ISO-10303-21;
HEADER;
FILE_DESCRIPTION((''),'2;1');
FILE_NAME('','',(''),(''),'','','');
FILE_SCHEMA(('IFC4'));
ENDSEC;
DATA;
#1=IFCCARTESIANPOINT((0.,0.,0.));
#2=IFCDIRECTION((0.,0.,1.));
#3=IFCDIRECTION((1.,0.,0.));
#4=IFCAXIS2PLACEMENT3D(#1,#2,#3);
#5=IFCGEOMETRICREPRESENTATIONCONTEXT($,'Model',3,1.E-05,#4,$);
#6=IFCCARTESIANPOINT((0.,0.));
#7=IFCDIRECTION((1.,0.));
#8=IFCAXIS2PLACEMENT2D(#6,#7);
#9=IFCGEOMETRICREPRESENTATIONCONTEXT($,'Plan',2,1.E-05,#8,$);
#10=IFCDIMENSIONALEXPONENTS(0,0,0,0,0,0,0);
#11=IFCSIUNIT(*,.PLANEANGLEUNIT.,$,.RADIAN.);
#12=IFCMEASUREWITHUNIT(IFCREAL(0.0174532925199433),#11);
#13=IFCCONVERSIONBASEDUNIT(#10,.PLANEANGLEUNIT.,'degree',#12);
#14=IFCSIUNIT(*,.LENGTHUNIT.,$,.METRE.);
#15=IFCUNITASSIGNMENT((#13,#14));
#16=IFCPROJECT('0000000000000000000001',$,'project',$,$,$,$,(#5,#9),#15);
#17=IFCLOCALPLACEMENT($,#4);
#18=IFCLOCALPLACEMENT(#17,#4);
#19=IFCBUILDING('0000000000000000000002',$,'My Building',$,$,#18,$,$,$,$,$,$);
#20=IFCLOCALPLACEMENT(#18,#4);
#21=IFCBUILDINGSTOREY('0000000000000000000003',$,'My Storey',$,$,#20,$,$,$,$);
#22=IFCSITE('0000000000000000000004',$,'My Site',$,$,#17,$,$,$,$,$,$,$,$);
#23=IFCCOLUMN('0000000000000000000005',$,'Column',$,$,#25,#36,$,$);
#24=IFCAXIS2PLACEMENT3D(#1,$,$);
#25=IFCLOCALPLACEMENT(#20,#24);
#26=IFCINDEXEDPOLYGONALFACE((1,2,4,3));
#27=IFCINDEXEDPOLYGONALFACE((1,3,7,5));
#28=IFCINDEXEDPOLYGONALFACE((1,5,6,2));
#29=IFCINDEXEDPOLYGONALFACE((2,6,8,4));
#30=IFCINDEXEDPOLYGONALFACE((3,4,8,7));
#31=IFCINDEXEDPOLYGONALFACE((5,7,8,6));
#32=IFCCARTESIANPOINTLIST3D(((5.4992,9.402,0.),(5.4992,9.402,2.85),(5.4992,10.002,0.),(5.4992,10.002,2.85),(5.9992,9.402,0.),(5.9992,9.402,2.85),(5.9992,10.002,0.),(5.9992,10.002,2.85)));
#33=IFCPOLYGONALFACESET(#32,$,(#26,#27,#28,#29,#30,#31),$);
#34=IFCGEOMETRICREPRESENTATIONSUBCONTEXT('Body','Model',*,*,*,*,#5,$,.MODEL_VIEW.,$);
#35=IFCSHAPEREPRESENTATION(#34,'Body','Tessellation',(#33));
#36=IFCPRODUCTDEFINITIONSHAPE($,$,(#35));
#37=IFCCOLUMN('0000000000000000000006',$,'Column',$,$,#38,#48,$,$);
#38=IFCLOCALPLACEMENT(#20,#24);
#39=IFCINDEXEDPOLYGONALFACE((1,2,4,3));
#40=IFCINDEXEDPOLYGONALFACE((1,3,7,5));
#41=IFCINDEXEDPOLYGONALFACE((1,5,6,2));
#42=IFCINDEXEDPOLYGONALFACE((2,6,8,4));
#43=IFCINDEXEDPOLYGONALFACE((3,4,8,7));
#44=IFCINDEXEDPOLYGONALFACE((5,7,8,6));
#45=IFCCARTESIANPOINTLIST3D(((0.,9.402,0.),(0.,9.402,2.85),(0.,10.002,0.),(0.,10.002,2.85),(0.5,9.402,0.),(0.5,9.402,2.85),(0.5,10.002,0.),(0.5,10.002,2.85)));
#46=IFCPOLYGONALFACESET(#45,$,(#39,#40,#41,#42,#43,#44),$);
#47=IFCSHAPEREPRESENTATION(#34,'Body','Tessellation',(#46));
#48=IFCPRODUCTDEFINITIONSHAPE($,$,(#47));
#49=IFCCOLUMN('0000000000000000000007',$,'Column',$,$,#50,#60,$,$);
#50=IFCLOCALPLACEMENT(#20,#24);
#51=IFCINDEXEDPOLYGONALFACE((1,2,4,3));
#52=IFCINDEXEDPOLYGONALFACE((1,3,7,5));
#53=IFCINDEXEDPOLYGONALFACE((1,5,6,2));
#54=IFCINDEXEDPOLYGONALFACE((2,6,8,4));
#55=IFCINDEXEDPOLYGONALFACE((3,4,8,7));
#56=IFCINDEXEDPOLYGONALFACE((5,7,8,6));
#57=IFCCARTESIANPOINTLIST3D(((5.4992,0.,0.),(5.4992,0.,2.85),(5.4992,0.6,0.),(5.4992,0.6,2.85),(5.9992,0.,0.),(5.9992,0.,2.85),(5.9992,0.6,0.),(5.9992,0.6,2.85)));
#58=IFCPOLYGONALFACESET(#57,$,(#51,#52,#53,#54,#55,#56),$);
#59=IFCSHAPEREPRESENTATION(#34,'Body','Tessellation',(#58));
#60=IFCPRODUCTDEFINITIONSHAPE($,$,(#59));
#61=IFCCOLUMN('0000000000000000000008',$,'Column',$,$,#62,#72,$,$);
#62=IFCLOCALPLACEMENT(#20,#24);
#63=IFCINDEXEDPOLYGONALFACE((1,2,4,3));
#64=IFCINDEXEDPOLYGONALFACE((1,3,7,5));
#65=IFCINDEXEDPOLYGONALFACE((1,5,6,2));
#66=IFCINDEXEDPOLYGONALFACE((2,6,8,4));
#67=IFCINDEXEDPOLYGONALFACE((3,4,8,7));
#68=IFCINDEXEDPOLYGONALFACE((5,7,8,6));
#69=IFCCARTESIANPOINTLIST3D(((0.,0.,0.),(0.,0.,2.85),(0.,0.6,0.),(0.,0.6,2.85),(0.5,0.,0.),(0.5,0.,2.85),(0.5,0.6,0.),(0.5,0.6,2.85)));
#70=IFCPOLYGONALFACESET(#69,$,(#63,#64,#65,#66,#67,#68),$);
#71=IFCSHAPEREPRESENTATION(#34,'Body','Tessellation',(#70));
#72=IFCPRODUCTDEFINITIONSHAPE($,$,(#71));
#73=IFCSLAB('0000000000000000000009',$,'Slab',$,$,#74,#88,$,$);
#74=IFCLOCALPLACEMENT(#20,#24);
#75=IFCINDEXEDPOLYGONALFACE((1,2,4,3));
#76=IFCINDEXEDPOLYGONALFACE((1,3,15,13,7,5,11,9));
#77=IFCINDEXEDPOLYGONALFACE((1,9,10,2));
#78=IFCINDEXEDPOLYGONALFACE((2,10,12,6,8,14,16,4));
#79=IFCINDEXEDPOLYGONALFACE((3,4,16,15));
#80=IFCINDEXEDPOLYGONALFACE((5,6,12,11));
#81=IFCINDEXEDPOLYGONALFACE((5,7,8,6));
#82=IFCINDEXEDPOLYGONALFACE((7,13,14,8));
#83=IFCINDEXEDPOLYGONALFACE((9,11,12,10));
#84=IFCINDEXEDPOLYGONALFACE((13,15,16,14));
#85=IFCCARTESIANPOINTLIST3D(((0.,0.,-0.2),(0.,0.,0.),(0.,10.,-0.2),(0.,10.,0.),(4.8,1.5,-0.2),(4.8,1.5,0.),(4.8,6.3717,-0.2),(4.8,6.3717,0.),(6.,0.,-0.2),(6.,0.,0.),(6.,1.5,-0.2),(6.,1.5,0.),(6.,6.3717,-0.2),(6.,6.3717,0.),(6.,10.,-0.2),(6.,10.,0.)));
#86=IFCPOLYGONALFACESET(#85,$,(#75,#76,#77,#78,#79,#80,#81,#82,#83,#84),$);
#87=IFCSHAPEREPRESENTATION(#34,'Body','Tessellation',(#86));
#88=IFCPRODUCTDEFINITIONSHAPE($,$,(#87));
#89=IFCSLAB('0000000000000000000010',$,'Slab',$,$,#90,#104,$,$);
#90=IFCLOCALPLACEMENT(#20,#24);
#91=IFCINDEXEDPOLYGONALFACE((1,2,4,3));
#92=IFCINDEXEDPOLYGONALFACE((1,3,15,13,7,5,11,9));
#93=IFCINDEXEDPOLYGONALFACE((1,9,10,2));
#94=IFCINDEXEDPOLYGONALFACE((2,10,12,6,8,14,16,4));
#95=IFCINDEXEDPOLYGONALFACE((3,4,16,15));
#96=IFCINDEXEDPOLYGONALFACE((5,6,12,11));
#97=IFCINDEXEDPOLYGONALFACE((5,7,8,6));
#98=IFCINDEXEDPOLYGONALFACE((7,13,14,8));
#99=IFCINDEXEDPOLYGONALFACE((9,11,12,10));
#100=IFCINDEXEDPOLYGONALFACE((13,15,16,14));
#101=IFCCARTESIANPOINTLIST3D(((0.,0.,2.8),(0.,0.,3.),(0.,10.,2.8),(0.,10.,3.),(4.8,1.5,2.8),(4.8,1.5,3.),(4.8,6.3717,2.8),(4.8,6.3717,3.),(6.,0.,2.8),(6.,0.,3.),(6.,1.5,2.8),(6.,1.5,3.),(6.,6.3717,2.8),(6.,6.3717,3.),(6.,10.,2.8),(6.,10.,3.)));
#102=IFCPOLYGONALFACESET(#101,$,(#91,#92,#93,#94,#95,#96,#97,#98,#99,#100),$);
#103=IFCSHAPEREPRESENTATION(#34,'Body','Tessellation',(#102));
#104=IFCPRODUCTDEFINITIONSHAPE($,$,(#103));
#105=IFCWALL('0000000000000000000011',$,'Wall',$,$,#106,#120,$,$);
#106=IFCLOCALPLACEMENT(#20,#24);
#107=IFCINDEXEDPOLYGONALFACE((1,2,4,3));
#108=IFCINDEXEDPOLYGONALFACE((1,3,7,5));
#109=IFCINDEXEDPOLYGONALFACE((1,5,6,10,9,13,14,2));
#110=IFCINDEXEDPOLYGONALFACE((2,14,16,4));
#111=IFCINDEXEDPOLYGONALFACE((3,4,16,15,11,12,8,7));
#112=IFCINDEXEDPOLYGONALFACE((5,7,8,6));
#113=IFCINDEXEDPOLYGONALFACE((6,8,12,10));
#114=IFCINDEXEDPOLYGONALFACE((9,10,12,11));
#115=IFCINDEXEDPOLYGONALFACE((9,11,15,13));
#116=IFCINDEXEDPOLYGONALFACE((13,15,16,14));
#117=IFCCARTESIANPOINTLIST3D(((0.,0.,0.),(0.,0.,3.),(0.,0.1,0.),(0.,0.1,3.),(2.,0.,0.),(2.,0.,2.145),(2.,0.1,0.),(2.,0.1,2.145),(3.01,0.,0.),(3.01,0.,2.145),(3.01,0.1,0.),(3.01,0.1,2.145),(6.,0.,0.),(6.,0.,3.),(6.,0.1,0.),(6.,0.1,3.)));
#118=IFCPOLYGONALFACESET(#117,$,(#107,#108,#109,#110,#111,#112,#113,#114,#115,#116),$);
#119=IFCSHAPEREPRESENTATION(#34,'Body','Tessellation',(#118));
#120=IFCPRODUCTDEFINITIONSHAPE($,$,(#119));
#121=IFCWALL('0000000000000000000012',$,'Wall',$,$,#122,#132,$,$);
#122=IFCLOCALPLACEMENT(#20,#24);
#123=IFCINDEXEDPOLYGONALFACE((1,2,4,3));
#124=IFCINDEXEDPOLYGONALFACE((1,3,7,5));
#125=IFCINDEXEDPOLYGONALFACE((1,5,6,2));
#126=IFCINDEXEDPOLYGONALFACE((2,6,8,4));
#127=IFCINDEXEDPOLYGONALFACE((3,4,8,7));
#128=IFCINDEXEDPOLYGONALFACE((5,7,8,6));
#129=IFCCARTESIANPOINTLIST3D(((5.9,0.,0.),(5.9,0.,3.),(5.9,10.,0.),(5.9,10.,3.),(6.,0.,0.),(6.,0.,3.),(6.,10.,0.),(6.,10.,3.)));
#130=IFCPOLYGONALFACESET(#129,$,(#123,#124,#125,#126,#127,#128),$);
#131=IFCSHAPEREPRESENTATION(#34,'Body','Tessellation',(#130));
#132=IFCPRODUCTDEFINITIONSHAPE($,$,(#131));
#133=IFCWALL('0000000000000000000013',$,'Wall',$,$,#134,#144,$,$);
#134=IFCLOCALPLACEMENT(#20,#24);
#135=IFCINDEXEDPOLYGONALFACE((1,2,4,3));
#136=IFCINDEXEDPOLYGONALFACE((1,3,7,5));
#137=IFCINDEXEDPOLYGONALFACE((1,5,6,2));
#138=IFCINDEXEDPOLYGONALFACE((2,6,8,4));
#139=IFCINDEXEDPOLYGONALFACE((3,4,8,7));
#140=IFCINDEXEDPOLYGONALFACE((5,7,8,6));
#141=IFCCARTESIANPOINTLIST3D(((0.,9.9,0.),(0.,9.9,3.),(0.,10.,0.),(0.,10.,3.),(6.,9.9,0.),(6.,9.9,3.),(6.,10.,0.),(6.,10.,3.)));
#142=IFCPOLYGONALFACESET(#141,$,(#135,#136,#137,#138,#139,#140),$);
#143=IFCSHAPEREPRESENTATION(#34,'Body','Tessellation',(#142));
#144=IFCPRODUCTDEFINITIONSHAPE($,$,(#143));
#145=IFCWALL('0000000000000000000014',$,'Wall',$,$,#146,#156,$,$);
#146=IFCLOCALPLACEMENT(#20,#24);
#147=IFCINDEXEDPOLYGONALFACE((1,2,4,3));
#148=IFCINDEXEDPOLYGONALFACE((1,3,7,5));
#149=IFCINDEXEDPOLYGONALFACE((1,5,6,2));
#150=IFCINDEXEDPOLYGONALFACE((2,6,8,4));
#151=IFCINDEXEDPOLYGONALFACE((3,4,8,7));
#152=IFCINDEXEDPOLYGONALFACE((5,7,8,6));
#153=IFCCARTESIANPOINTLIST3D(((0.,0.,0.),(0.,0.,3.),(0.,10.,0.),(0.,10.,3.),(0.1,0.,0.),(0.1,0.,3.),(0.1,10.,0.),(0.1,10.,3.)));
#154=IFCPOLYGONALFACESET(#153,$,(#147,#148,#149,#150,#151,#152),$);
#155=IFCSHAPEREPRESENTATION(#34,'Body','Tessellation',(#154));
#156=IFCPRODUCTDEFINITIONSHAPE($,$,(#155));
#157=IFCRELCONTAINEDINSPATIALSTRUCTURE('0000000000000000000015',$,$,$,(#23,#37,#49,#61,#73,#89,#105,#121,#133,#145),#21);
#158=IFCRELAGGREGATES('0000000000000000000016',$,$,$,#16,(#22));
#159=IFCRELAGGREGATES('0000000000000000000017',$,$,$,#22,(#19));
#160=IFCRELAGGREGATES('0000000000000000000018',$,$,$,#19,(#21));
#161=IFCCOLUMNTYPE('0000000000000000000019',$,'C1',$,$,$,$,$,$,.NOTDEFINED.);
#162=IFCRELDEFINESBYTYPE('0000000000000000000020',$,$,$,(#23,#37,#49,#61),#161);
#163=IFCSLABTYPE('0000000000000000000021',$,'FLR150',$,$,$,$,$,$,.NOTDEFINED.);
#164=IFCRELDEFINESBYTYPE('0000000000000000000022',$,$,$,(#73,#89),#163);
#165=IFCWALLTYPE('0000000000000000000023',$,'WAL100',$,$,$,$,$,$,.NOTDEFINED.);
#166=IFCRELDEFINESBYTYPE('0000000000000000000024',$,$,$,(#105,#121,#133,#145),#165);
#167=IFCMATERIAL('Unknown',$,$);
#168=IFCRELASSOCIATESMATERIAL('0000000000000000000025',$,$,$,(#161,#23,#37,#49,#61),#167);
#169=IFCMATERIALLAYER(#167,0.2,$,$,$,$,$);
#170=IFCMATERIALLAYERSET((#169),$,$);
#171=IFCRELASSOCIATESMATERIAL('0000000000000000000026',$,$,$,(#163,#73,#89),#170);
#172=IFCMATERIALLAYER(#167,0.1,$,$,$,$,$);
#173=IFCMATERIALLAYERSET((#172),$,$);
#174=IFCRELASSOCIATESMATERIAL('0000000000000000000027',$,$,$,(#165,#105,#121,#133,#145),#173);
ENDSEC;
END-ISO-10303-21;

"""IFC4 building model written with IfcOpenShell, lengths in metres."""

from ifc_helpers import new_model, entity, si_unit, converted_unit, frame, origin_with_axes, origin_2d_with_axis, place, context, subcontext, project, spatial, line, indexed_curve, rectangle, outline, extrude, source, transform, mapped, material, layer, layer_set, layer_usage, material_profile, profile_set, profile_usage, type_object, element, save


model = new_model("IFC4")

# Units and contexts
model_context = context("Model", 3, precision=1e-05, world=origin_with_axes())
plan_context = context("Plan", 2, precision=1e-05, world=origin_2d_with_axis())
body_context = subcontext(model_context, "Body", "Model", "MODEL_VIEW")
ifc_project = project(units=[converted_unit("PLANEANGLEUNIT", "degree", entity("IfcReal", 0.0174532925199433), si_unit("PLANEANGLEUNIT", "RADIAN"), dimensions=[0, 0, 0, 0, 0, 0, 0]), si_unit("LENGTHUNIT", "METRE")], contexts=[model_context, plan_context])

# Site, building, storey
site_placement = place(None, origin_with_axes())
site = spatial("IfcSite", under=ifc_project, at=site_placement, Name="My Site")
building_placement = place(site_placement, origin_with_axes())
building = spatial("IfcBuilding", under=site, at=building_placement, Name="My Building")
storey_placement = place(building_placement, origin_with_axes())
storey = spatial("IfcBuildingStorey", under=building, at=storey_placement, Name="My Storey")

# Columns
ifc_material = material(Name="Unknown")
ifc_material_profile = material_profile(ifc_material, rectangle(XDim=0.5, YDim=0.6))
ifc_profile_set = profile_set([ifc_material_profile])
ifc_profile_usage_1 = profile_usage(ifc_profile_set, cardinal=5)
column_type = type_object("IfcColumnType", Name="C1", PredefinedType="NOTDEFINED", material=ifc_profile_set)
column_1_placement = place(storey_placement, frame((5.7492, 9.702, 0.0), z_axis=(0.0, 0.0, 1.0), x_axis=(1.0, 0.0, 0.0)))
element("IfcColumn", 1, at=column_1_placement, inside=storey, type_object=column_type, material=ifc_profile_usage_1, Name="Column", context=body_context, shape_type="SweptSolid", body=[
    extrude(rectangle(XDim=0.5, YDim=0.6), origin_with_axes(), (0.0, 0.0, 1.0), 2.85),
])
ifc_profile_usage_2 = profile_usage(ifc_profile_set, cardinal=5)
column_2_placement = place(storey_placement, frame((0.25, 9.702, 0.0), z_axis=(0.0, 0.0, 1.0), x_axis=(1.0, 0.0, 0.0)))
element("IfcColumn", 2, at=column_2_placement, inside=storey, type_object=column_type, material=ifc_profile_usage_2, Name="Column", context=body_context, shape_type="SweptSolid", body=[
    extrude(rectangle(XDim=0.5, YDim=0.6), origin_with_axes(), (0.0, 0.0, 1.0), 2.85),
])
ifc_profile_usage_3 = profile_usage(ifc_profile_set, cardinal=5)
column_3_placement = place(storey_placement, frame((5.7492, 0.3, 0.0), z_axis=(0.0, 0.0, 1.0), x_axis=(1.0, 0.0, 0.0)))
element("IfcColumn", 3, at=column_3_placement, inside=storey, type_object=column_type, material=ifc_profile_usage_3, Name="Column", context=body_context, shape_type="SweptSolid", body=[
    extrude(rectangle(XDim=0.5, YDim=0.6), origin_with_axes(), (0.0, 0.0, 1.0), 2.85),
])
ifc_profile_usage_4 = profile_usage(ifc_profile_set, cardinal=5)
column_4_placement = place(storey_placement, frame((0.25, 0.3, 0.0), z_axis=(0.0, 0.0, 1.0), x_axis=(1.0, 0.0, 0.0)))
element("IfcColumn", 4, at=column_4_placement, inside=storey, type_object=column_type, material=ifc_profile_usage_4, Name="Column", context=body_context, shape_type="SweptSolid", body=[
    extrude(rectangle(XDim=0.5, YDim=0.6), origin_with_axes(), (0.0, 0.0, 1.0), 2.85),
])

# Slabs
ifc_layer_1 = layer(ifc_material, 0.2)
ifc_layer_set_1 = layer_set([ifc_layer_1])
ifc_layer_usage_1 = layer_usage(ifc_layer_set_1, "AXIS3", "POSITIVE", 0.0)
slab_type = type_object("IfcSlabType", Name="FLR150", PredefinedType="NOTDEFINED", material=ifc_layer_set_1)
slab_1_placement = place(storey_placement, frame((0.0, 0.0, -0.2), z_axis=(0.0, 0.0, 1.0), x_axis=(1.0, 0.0, 0.0)))
element("IfcSlab", 5, at=slab_1_placement, inside=storey, type_object=slab_type, material=ifc_layer_usage_1, Name="Slab", context=body_context, shape_type="SweptSolid", body=[
    extrude(outline(indexed_curve([(6.0, 1.5), (6.0, 0.0), (0.0, 0.0), (0.0, 10.0), (6.0, 10.0), (6.0, 6.3717), (4.8, 6.3717), (4.8, 1.5)], segments=[line(1, 8), line(8, 7), line(7, 6), line(6, 5), line(5, 4), line(4, 3), line(3, 2), line(2, 1)], self_intersect=False)), None, (0.0, 0.0, 1.0), 0.2),
])
ifc_layer_usage_2 = layer_usage(ifc_layer_set_1, "AXIS3", "POSITIVE", 0.0)
slab_2_placement = place(storey_placement, frame((0.0, 0.0, 2.8), z_axis=(0.0, 0.0, 1.0), x_axis=(1.0, 0.0, 0.0)))
element("IfcSlab", 6, at=slab_2_placement, inside=storey, type_object=slab_type, material=ifc_layer_usage_2, Name="Slab", context=body_context, shape_type="SweptSolid", body=[
    extrude(outline(indexed_curve([(6.0, 1.5), (4.8, 1.5), (4.8, 6.3717), (6.0, 6.3717), (6.0, 10.0), (0.0, 10.0), (0.0, 0.0), (6.0, 0.0)], segments=[line(5, 6), line(6, 7), line(7, 8), line(8, 1), line(1, 2), line(2, 3), line(3, 4), line(4, 5)], self_intersect=False)), None, (0.0, 0.0, 1.0), 0.2),
])

# Wall, opening
ifc_layer_2 = layer(ifc_material, 0.1)
ifc_layer_set_2 = layer_set([ifc_layer_2])
ifc_layer_usage_3 = layer_usage(ifc_layer_set_2, "AXIS2", "POSITIVE", 0.0)
wall_type = type_object("IfcWallType", Name="WAL100", PredefinedType="NOTDEFINED", material=ifc_layer_set_2)
wall_1_placement = place(storey_placement, frame((0.0, 0.0, 0.0), z_axis=(0.0, 0.0, 1.0), x_axis=(1.0, 0.0, 0.0)))
wall_1 = element("IfcWall", 7, at=wall_1_placement, inside=storey, type_object=wall_type, material=ifc_layer_usage_3, Name="Wall", context=body_context, shape_type="SweptSolid", body=[
    extrude(outline(indexed_curve([(0.0, 0.0), (0.0, 0.1), (6.0, 0.1), (6.0, 0.0), (0.0, 0.0)], self_intersect=False)), origin_with_axes(), (0.0, 0.0, 1.0), 3.0),
])
shared_shape = source(origin_with_axes(), body_context, "Body", "SweptSolid", [
    extrude(outline(indexed_curve([(0.0, 0.0), (1.01, 0.0), (1.01, 2.145), (0.0, 2.145)], segments=[line(1, 2, 3, 4, 1)])), frame((0.0, -0.1, 0.0), z_axis=(0.0, -1.0, 0.0), x_axis=(1.0, 0.0, 0.0)), (0.0, 0.0, -1.0), 0.3),
])
opening_placement = place(wall_1_placement, frame((2.0, 0.0, 0.0), z_axis=(0.0, 0.0, 1.0), x_axis=(1.0, 0.0, 0.0)))
element("IfcOpeningElement", 8, at=opening_placement, cuts=wall_1, PredefinedType="OPENING", context=body_context, shape_type="MappedRepresentation", body=[
    mapped(shared_shape, transform((0.0, 0.0, 0.0), x_axis=(1.0, 0.0, 0.0), y_axis=(0.0, 1.0, 0.0), z_axis=(0.0, 0.0, 1.0), scale=1.0)),
])

# Walls
ifc_layer_usage_4 = layer_usage(ifc_layer_set_2, "AXIS2", "POSITIVE", 0.0)
wall_2_placement = place(storey_placement, frame((6.0, 0.0, 0.0), z_axis=(0.0, 0.0, 1.0), x_axis=(0.0, 1.0, 0.0)))
element("IfcWall", 9, at=wall_2_placement, inside=storey, type_object=wall_type, material=ifc_layer_usage_4, Name="Wall", context=body_context, shape_type="SweptSolid", body=[
    extrude(outline(indexed_curve([(0.0, 0.0), (0.0, 0.1), (10.0, 0.1), (10.0, 0.0), (0.0, 0.0)], self_intersect=False)), origin_with_axes(), (0.0, 0.0, 1.0), 3.0),
])
ifc_layer_usage_5 = layer_usage(ifc_layer_set_2, "AXIS2", "POSITIVE", 0.0)
wall_3_placement = place(storey_placement, frame((6.0, 10.0, 0.0), z_axis=(0.0, 0.0, 1.0), x_axis=(-1.0, 0.000001, 0.0)))
element("IfcWall", 10, at=wall_3_placement, inside=storey, type_object=wall_type, material=ifc_layer_usage_5, Name="Wall", context=body_context, shape_type="SweptSolid", body=[
    extrude(outline(indexed_curve([(0.0, 0.0), (0.0, 0.1), (6.0, 0.1), (6.0, 0.0), (0.0, 0.0)], self_intersect=False)), origin_with_axes(), (0.0, 0.0, 1.0), 3.0),
])
ifc_layer_usage_6 = layer_usage(ifc_layer_set_2, "AXIS2", "POSITIVE", 0.0)
wall_4_placement = place(storey_placement, frame((0.0, 10.0, 0.0), z_axis=(0.0, 0.0, 1.0), x_axis=(-0.000001, -1.0, 0.0)))
element("IfcWall", 11, at=wall_4_placement, inside=storey, type_object=wall_type, material=ifc_layer_usage_6, Name="Wall", context=body_context, shape_type="SweptSolid", body=[
    extrude(outline(indexed_curve([(0.0, 0.0), (0.0, 0.1), (10.0, 0.1), (10.0, 0.0), (0.0, 0.0)], self_intersect=False)), origin_with_axes(), (0.0, 0.0, 1.0), 3.0),
])

save(model, "model.ifc")
